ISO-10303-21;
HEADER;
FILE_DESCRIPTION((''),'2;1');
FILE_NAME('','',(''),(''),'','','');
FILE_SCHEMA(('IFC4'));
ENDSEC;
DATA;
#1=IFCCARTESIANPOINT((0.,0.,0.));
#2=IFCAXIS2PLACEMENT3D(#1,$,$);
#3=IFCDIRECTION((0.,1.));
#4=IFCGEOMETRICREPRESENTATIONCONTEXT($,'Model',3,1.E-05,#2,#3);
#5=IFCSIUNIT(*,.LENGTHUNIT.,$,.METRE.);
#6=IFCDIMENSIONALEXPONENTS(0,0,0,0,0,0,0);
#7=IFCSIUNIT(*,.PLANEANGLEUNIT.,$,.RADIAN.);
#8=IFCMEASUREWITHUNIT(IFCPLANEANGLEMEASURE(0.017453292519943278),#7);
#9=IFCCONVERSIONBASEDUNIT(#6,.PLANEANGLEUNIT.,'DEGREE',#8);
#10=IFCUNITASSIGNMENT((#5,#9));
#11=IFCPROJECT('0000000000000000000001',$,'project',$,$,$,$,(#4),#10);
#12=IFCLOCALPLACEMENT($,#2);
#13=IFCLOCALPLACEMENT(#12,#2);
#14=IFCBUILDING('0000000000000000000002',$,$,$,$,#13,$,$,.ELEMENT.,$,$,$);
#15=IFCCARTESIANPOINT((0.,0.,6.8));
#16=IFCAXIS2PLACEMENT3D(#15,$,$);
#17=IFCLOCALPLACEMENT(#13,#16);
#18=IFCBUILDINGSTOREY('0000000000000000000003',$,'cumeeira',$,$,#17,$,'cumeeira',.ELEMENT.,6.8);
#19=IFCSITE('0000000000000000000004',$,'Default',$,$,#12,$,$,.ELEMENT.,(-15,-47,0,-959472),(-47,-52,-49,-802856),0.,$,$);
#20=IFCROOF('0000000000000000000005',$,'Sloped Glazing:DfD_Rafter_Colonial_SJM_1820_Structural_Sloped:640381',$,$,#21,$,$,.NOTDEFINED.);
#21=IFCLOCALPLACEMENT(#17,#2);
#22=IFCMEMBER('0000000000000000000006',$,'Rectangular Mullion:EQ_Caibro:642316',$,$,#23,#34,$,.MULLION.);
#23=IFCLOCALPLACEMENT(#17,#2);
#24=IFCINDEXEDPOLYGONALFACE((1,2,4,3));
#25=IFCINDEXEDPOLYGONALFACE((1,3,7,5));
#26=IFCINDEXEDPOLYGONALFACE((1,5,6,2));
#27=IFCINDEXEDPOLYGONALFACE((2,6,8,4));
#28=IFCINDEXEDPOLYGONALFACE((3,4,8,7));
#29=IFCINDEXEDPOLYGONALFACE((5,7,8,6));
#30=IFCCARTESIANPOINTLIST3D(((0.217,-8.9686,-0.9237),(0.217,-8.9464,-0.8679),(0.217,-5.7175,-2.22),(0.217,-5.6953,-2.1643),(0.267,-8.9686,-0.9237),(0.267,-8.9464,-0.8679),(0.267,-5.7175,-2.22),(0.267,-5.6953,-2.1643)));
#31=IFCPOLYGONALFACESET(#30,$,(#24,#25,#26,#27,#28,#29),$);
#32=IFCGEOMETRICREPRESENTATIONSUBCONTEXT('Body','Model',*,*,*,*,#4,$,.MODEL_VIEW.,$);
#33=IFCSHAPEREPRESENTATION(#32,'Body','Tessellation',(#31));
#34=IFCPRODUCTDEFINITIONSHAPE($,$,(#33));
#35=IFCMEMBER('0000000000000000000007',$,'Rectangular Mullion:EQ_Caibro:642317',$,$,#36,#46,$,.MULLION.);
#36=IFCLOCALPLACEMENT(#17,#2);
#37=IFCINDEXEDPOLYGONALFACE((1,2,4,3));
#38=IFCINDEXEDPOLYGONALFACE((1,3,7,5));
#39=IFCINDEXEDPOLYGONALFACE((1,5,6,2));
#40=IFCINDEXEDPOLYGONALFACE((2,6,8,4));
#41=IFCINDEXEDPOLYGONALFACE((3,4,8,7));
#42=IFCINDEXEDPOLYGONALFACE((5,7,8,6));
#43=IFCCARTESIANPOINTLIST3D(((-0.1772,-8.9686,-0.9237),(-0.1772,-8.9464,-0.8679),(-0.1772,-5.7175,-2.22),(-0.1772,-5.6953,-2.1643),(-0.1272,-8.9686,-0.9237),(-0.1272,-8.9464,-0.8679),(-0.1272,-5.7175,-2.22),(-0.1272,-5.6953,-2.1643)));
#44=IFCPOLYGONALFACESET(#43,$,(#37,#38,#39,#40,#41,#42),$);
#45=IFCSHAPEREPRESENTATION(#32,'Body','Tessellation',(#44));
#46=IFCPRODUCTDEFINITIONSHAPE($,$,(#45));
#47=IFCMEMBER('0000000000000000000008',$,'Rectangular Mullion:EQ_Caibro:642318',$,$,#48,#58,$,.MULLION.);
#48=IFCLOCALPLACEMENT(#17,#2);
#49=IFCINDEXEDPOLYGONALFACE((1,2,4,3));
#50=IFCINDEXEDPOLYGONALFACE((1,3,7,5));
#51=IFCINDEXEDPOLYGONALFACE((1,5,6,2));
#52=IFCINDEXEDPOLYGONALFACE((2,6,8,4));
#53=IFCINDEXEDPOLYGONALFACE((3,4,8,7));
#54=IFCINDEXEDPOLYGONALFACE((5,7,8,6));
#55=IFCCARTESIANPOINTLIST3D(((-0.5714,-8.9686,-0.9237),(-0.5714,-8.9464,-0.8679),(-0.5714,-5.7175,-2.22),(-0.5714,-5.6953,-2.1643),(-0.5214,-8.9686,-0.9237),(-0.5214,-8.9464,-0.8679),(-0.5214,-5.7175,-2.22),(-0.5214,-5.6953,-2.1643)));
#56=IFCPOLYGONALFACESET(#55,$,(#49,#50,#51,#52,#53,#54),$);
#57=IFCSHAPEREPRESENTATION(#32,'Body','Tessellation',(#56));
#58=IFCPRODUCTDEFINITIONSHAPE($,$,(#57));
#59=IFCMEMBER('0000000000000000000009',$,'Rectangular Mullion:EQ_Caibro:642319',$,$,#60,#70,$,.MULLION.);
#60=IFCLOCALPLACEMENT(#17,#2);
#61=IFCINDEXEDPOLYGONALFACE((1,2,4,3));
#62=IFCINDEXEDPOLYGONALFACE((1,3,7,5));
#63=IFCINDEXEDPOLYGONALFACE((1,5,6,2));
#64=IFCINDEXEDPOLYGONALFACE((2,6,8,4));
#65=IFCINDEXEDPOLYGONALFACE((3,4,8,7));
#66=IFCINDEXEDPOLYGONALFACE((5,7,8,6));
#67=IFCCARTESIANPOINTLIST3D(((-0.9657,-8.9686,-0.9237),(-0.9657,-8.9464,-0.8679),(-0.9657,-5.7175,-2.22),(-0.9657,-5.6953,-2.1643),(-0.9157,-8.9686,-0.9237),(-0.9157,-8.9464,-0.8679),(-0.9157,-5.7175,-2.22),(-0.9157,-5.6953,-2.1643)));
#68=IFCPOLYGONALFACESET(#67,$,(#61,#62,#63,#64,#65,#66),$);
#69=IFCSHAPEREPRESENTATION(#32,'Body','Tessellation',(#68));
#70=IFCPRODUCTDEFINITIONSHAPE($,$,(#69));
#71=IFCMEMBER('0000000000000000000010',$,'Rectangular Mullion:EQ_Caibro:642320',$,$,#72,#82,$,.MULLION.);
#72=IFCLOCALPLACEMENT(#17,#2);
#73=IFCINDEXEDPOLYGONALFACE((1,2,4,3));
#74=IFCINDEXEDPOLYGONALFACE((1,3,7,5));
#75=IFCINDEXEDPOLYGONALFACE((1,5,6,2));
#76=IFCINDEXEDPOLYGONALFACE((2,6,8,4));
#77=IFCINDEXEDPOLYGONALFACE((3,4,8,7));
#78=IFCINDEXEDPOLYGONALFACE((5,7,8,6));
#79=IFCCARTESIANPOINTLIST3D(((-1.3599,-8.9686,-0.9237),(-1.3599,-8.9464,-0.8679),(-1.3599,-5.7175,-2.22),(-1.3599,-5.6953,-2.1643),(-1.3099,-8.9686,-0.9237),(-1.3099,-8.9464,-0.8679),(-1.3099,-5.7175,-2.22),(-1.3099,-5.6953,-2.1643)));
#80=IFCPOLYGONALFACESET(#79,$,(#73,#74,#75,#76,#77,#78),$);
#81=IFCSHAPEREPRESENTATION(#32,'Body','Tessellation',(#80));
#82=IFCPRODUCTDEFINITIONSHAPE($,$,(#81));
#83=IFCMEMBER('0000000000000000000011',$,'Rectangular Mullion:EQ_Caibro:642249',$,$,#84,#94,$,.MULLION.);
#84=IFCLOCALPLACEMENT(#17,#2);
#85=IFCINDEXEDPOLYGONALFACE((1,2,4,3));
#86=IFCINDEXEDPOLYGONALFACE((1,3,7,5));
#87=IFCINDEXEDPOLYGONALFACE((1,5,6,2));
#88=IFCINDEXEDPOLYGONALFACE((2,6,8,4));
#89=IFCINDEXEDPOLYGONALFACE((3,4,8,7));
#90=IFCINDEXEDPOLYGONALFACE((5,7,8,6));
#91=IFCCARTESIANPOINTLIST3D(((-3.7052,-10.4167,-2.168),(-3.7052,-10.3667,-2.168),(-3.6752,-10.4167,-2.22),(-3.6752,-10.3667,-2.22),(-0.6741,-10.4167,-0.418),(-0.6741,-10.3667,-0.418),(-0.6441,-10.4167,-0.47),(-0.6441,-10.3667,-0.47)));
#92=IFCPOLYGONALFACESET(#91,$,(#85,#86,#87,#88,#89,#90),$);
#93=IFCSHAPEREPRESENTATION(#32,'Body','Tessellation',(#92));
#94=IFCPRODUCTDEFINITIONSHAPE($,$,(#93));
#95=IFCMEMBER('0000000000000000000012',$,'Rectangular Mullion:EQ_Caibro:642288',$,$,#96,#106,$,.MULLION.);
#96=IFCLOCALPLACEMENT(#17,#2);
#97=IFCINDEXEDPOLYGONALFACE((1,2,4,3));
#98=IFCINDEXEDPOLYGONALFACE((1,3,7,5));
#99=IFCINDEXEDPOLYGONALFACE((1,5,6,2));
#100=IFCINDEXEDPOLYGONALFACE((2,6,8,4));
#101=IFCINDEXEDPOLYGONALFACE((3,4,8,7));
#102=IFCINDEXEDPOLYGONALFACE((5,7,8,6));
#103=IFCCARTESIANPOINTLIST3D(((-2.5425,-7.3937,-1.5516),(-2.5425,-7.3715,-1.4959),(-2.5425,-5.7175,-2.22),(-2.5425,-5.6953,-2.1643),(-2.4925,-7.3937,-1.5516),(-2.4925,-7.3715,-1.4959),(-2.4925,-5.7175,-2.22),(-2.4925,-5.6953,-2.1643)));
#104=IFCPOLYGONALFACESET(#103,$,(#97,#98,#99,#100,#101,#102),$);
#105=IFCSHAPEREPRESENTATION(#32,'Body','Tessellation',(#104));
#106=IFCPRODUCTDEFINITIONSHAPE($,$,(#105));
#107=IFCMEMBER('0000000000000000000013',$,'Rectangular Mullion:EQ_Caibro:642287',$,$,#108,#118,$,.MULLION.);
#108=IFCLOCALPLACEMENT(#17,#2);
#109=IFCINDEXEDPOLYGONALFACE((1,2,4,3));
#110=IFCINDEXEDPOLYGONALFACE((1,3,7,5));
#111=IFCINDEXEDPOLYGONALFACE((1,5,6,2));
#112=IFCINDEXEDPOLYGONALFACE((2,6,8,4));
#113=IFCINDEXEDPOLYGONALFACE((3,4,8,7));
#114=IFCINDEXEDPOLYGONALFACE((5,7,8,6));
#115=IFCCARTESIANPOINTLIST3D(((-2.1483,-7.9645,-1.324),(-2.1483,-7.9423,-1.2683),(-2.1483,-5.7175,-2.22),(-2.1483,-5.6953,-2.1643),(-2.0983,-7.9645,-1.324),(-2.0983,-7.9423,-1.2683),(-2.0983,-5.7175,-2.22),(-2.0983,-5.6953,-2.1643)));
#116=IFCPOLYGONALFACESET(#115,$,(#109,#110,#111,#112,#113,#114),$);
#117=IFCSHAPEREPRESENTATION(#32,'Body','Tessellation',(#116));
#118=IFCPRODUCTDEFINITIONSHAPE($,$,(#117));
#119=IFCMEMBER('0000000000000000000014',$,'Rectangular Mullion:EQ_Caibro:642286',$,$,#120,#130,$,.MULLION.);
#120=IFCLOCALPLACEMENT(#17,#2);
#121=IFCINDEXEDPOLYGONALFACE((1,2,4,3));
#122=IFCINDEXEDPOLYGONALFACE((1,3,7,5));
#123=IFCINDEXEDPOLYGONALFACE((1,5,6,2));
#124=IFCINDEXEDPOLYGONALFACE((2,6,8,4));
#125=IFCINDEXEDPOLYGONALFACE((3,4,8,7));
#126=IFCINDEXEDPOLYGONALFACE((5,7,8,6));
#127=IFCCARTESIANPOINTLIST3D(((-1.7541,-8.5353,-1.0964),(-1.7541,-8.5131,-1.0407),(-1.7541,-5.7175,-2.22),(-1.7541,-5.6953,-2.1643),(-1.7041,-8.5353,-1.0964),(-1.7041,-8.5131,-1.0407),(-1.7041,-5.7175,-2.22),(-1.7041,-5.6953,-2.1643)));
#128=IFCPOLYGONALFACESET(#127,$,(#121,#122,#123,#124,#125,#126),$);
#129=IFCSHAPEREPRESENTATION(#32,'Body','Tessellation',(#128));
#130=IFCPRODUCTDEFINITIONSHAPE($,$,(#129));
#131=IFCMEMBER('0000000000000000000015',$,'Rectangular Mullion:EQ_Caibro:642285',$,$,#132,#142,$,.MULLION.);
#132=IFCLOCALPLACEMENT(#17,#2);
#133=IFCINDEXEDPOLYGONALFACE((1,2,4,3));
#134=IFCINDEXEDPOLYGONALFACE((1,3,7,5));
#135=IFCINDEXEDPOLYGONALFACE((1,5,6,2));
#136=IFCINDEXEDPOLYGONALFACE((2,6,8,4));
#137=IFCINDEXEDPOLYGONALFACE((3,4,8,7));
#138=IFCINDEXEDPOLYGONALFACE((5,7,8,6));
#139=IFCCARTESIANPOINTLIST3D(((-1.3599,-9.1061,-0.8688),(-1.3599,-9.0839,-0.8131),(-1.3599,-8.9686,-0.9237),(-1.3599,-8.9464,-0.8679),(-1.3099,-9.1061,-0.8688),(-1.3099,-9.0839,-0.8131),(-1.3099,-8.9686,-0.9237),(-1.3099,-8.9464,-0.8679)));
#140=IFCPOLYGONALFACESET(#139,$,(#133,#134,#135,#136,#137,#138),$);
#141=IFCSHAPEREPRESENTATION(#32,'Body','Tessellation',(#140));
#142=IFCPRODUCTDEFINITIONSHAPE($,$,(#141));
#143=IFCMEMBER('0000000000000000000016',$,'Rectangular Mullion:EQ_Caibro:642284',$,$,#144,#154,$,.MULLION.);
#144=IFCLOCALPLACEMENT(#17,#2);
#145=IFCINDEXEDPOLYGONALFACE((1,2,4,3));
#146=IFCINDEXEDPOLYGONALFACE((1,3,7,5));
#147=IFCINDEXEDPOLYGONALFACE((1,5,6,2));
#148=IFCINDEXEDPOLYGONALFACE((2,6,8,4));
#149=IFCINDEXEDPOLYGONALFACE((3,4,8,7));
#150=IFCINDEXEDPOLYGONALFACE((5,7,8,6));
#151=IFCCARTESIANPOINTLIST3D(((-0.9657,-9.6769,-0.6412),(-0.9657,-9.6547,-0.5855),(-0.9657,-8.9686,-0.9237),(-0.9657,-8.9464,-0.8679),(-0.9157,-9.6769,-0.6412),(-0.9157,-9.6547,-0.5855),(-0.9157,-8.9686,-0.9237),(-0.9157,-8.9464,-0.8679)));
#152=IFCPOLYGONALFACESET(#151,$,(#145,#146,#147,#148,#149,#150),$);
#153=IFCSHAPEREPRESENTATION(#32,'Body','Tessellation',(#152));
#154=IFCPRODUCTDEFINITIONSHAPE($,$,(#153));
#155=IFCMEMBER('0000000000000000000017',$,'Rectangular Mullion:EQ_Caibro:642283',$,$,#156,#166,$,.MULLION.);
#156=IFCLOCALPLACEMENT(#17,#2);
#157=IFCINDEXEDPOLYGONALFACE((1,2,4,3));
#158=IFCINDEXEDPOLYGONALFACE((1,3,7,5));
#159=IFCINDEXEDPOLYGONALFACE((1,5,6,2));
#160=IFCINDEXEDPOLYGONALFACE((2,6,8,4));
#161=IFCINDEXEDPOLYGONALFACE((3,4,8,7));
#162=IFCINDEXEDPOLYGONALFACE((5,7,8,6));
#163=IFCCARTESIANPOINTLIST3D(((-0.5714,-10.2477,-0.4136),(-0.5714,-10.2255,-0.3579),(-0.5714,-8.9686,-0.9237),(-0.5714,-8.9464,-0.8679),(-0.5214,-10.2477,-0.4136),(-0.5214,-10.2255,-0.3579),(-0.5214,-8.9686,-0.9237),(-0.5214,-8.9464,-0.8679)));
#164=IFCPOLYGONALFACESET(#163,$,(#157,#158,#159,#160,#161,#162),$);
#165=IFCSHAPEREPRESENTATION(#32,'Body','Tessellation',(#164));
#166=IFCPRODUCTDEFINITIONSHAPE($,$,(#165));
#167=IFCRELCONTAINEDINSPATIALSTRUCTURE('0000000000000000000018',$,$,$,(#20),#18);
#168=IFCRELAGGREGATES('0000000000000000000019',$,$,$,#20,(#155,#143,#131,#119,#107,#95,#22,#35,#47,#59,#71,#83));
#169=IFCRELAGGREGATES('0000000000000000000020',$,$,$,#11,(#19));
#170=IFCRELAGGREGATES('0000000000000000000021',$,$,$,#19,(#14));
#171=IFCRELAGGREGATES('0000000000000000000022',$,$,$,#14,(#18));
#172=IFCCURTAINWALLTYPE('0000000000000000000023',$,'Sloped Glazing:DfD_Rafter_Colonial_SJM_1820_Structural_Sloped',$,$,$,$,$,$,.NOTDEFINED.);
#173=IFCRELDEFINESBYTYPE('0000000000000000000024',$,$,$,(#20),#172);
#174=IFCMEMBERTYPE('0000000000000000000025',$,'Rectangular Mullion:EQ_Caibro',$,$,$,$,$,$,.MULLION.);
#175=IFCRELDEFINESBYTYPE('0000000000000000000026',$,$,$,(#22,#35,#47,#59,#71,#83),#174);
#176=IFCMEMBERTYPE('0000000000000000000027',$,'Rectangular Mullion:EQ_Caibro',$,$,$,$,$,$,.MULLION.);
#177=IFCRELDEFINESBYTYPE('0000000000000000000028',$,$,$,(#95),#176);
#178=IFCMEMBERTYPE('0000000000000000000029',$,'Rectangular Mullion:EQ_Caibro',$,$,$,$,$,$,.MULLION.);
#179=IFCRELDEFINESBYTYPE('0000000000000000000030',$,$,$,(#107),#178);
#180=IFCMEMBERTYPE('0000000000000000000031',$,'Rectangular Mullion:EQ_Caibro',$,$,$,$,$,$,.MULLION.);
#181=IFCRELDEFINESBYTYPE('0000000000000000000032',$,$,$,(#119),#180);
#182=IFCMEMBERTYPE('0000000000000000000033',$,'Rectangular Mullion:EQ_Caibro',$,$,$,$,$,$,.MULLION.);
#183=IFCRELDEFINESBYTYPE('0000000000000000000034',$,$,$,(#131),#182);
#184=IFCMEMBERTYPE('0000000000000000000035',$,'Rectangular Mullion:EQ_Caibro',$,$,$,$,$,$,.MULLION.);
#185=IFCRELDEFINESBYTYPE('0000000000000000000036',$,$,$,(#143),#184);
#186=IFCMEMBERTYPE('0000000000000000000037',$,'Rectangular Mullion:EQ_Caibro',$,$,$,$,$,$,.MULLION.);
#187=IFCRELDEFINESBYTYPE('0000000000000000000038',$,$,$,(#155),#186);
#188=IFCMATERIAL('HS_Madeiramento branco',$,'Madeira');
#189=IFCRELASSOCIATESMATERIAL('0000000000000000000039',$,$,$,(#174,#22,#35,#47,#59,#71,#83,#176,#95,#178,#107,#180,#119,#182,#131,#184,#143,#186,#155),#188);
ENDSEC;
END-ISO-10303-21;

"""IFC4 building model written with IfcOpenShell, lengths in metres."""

from ifc_helpers import new_model, entity, si_unit, converted_unit, direction, frame, origin, place, context, subcontext, project, spatial, indexed_curve, outline, extrude, source, transform, mapped, material, type_object, type_shapes, element, aggregate, save


model = new_model("IFC4")

# Units and contexts
model_context = context("Model", 3, precision=1e-05, world=origin(), true_north=direction((0.0, 1.0)))
body_context = subcontext(model_context, "Body", "Model", "MODEL_VIEW")
ifc_project = project(units=[si_unit("LENGTHUNIT", "METRE"), converted_unit("PLANEANGLEUNIT", "DEGREE", entity("IfcPlaneAngleMeasure", 0.017453292519943278), si_unit("PLANEANGLEUNIT", "RADIAN"), dimensions=[0, 0, 0, 0, 0, 0, 0])], contexts=[model_context])

# Site, building, storey
site_placement = place(None, origin())
site = spatial("IfcSite", under=ifc_project, at=site_placement, Name="Default", CompositionType="ELEMENT", RefLatitude=(-15, -47, 0, -959472), RefLongitude=(-47, -52, -49, -802856), RefElevation=0.0)
building_placement = place(site_placement, origin())
building = spatial("IfcBuilding", under=site, at=building_placement, CompositionType="ELEMENT")
storey_placement = place(building_placement, frame((0.0, 0.0, 6.8)))
storey = spatial("IfcBuildingStorey", under=building, at=storey_placement, Name="cumeeira", LongName="cumeeira", CompositionType="ELEMENT", Elevation=6.8)

# Roof, members
curtain_wall_type = type_object("IfcCurtainWallType", Name="Sloped Glazing:DfD_Rafter_Colonial_SJM_1820_Structural_Sloped", PredefinedType="NOTDEFINED")
roof_placement = place(storey_placement, frame((0.0, 0.0, -6.8)))
roof = element("IfcRoof", 1, at=roof_placement, inside=storey, type_object=curtain_wall_type, Name="Sloped Glazing:DfD_Rafter_Colonial_SJM_1820_Structural_Sloped:640381", PredefinedType="NOTDEFINED")
ifc_material = material(Name="HS_Madeiramento branco", Category="Madeira")
member_type_1 = type_object("IfcMemberType", Name="Rectangular Mullion:EQ_Caibro", PredefinedType="MULLION", material=ifc_material)
shared_shape_1 = source(origin(), body_context, "Body", "SweptSolid", [
    extrude(outline(indexed_curve([(-0.025, -0.03), (0.025, -0.03), (0.025, 0.03), (-0.025, 0.03), (-0.025, -0.03)], self_intersect=False)), frame((0.0, -0.03, -3.5), z_axis=(0.0, 0.0, 1.0), x_axis=(-1.0, 0.0, 0.0)), (0.0, 0.0, 1.0), 3.5),
])
type_shapes(member_type_1, [shared_shape_1])
member_1_placement = place(roof_placement, frame((0.242, -8.9686, 5.8763), z_axis=(0.0, -0.928878, 0.370385), x_axis=(-1.0, 0.0, 0.0)))
member_1 = element("IfcMember", 2, at=member_1_placement, type_object=member_type_1, material=ifc_material, Name="Rectangular Mullion:EQ_Caibro:642316", PredefinedType="MULLION", context=body_context, shape_type="MappedRepresentation", body=[
    mapped(shared_shape_1, transform((0.0, 0.0, 0.0), scale=1.0)),
])
member_2_placement = place(roof_placement, frame((-0.1522, -8.9686, 5.8763), z_axis=(0.0, -0.928878, 0.370385), x_axis=(-1.0, 0.0, 0.0)))
member_2 = element("IfcMember", 3, at=member_2_placement, type_object=member_type_1, material=ifc_material, Name="Rectangular Mullion:EQ_Caibro:642317", PredefinedType="MULLION", context=body_context, shape_type="MappedRepresentation", body=[
    mapped(shared_shape_1, transform((0.0, 0.0, 0.0), scale=1.0)),
])
member_3_placement = place(roof_placement, frame((-0.5464, -8.9686, 5.8763), z_axis=(0.0, -0.928878, 0.370385), x_axis=(-1.0, 0.0, 0.0)))
member_3 = element("IfcMember", 4, at=member_3_placement, type_object=member_type_1, material=ifc_material, Name="Rectangular Mullion:EQ_Caibro:642318", PredefinedType="MULLION", context=body_context, shape_type="MappedRepresentation", body=[
    mapped(shared_shape_1, transform((0.0, 0.0, 0.0), scale=1.0)),
])
member_4_placement = place(roof_placement, frame((-0.9407, -8.9686, 5.8763), z_axis=(0.0, -0.928878, 0.370385), x_axis=(-1.0, 0.0, 0.0)))
member_4 = element("IfcMember", 5, at=member_4_placement, type_object=member_type_1, material=ifc_material, Name="Rectangular Mullion:EQ_Caibro:642319", PredefinedType="MULLION", context=body_context, shape_type="MappedRepresentation", body=[
    mapped(shared_shape_1, transform((0.0, 0.0, 0.0), scale=1.0)),
])
member_5_placement = place(roof_placement, frame((-1.3349, -8.9686, 5.8763), z_axis=(0.0, -0.928878, 0.370385), x_axis=(-1.0, 0.0, 0.0)))
member_5 = element("IfcMember", 6, at=member_5_placement, type_object=member_type_1, material=ifc_material, Name="Rectangular Mullion:EQ_Caibro:642320", PredefinedType="MULLION", context=body_context, shape_type="MappedRepresentation", body=[
    mapped(shared_shape_1, transform((0.0, 0.0, 0.0), scale=1.0)),
])
member_6_placement = place(roof_placement, frame((-0.6441, -10.3917, 6.33), z_axis=(0.866025, 0.0, 0.5), x_axis=(0.0, -1.0, 0.0)))
member_6 = element("IfcMember", 7, at=member_6_placement, type_object=member_type_1, material=ifc_material, Name="Rectangular Mullion:EQ_Caibro:642249", PredefinedType="MULLION", context=body_context, shape_type="MappedRepresentation", body=[
    mapped(shared_shape_1, transform((0.0, 0.0, 0.0), scale=1.0)),
])
member_type_2 = type_object("IfcMemberType", Name="Rectangular Mullion:EQ_Caibro", PredefinedType="MULLION", material=ifc_material)
shared_shape_2 = source(origin(), body_context, "Body", "SweptSolid", [
    extrude(outline(indexed_curve([(-0.025, -0.03), (0.025, -0.03), (0.025, 0.03), (-0.025, 0.03), (-0.025, -0.03)], self_intersect=False)), frame((0.0, -0.03, -1.8045), z_axis=(0.0, 0.0, 1.0), x_axis=(-1.0, 0.0, 0.0)), (0.0, 0.0, 1.0), 1.8045),
])
type_shapes(member_type_2, [shared_shape_2])
member_7_placement = place(roof_placement, frame((-2.5175, -7.3937, 5.2484), z_axis=(0.0, -0.928878, 0.370385), x_axis=(-1.0, 0.0, 0.0)))
member_7 = element("IfcMember", 8, at=member_7_placement, type_object=member_type_2, material=ifc_material, Name="Rectangular Mullion:EQ_Caibro:642288", PredefinedType="MULLION", context=body_context, shape_type="MappedRepresentation", body=[
    mapped(shared_shape_2, transform((0.0, 0.0, 0.0), scale=1.0)),
])
member_type_3 = type_object("IfcMemberType", Name="Rectangular Mullion:EQ_Caibro", PredefinedType="MULLION", material=ifc_material)
shared_shape_3 = source(origin(), body_context, "Body", "SweptSolid", [
    extrude(outline(indexed_curve([(-0.025, -0.03), (0.025, -0.03), (0.025, 0.03), (-0.025, 0.03), (-0.025, -0.03)], self_intersect=False)), frame((0.0, -0.03, -2.419), z_axis=(0.0, 0.0, 1.0), x_axis=(-1.0, 0.0, 0.0)), (0.0, 0.0, 1.0), 2.419),
])
type_shapes(member_type_3, [shared_shape_3])
member_8_placement = place(roof_placement, frame((-2.1233, -7.9645, 5.476), z_axis=(0.0, -0.928878, 0.370385), x_axis=(-1.0, 0.0, 0.0)))
member_8 = element("IfcMember", 9, at=member_8_placement, type_object=member_type_3, material=ifc_material, Name="Rectangular Mullion:EQ_Caibro:642287", PredefinedType="MULLION", context=body_context, shape_type="MappedRepresentation", body=[
    mapped(shared_shape_3, transform((0.0, 0.0, 0.0), scale=1.0)),
])
member_type_4 = type_object("IfcMemberType", Name="Rectangular Mullion:EQ_Caibro", PredefinedType="MULLION", material=ifc_material)
shared_shape_4 = source(origin(), body_context, "Body", "SweptSolid", [
    extrude(outline(indexed_curve([(-0.025, -0.03), (0.025, -0.03), (0.025, 0.03), (-0.025, 0.03), (-0.025, -0.03)], self_intersect=False)), frame((0.0, -0.03, -3.0335), z_axis=(0.0, 0.0, 1.0), x_axis=(-1.0, 0.0, 0.0)), (0.0, 0.0, 1.0), 3.0335),
])
type_shapes(member_type_4, [shared_shape_4])
member_9_placement = place(roof_placement, frame((-1.7291, -8.5353, 5.7036), z_axis=(0.0, -0.928878, 0.370385), x_axis=(-1.0, 0.0, 0.0)))
member_9 = element("IfcMember", 10, at=member_9_placement, type_object=member_type_4, material=ifc_material, Name="Rectangular Mullion:EQ_Caibro:642286", PredefinedType="MULLION", context=body_context, shape_type="MappedRepresentation", body=[
    mapped(shared_shape_4, transform((0.0, 0.0, 0.0), scale=1.0)),
])
member_type_5 = type_object("IfcMemberType", Name="Rectangular Mullion:EQ_Caibro", PredefinedType="MULLION", material=ifc_material)
shared_shape_5 = source(origin(), body_context, "Body", "SweptSolid", [
    extrude(outline(indexed_curve([(-0.025, -0.03), (0.025, -0.03), (0.025, 0.03), (-0.025, 0.03), (-0.025, -0.03)], self_intersect=False)), frame((0.0, -0.03, -0.148), z_axis=(0.0, 0.0, 1.0), x_axis=(-1.0, 0.0, 0.0)), (0.0, 0.0, 1.0), 0.148),
])
type_shapes(member_type_5, [shared_shape_5])
member_10_placement = place(roof_placement, frame((-1.3349, -9.1061, 5.9312), z_axis=(0.0, -0.928878, 0.370385), x_axis=(-1.0, 0.0, 0.0)))
member_10 = element("IfcMember", 11, at=member_10_placement, type_object=member_type_5, material=ifc_material, Name="Rectangular Mullion:EQ_Caibro:642285", PredefinedType="MULLION", context=body_context, shape_type="MappedRepresentation", body=[
    mapped(shared_shape_5, transform((0.0, 0.0, 0.0), scale=1.0)),
])
member_type_6 = type_object("IfcMemberType", Name="Rectangular Mullion:EQ_Caibro", PredefinedType="MULLION", material=ifc_material)
shared_shape_6 = source(origin(), body_context, "Body", "SweptSolid", [
    extrude(outline(indexed_curve([(-0.025, -0.03), (0.025, -0.03), (0.025, 0.03), (-0.025, 0.03), (-0.025, -0.03)], self_intersect=False)), frame((0.0, -0.03, -0.7625), z_axis=(0.0, 0.0, 1.0), x_axis=(-1.0, 0.0, 0.0)), (0.0, 0.0, 1.0), 0.7625),
])
type_shapes(member_type_6, [shared_shape_6])
member_11_placement = place(roof_placement, frame((-0.9407, -9.6769, 6.1588), z_axis=(0.0, -0.928878, 0.370385), x_axis=(-1.0, 0.0, 0.0)))
member_11 = element("IfcMember", 12, at=member_11_placement, type_object=member_type_6, material=ifc_material, Name="Rectangular Mullion:EQ_Caibro:642284", PredefinedType="MULLION", context=body_context, shape_type="MappedRepresentation", body=[
    mapped(shared_shape_6, transform((0.0, 0.0, 0.0), scale=1.0)),
])
member_type_7 = type_object("IfcMemberType", Name="Rectangular Mullion:EQ_Caibro", PredefinedType="MULLION", material=ifc_material)
shared_shape_7 = source(origin(), body_context, "Body", "SweptSolid", [
    extrude(outline(indexed_curve([(-0.025, -0.03), (0.025, -0.03), (0.025, 0.03), (-0.025, 0.03), (-0.025, -0.03)], self_intersect=False)), frame((0.0, -0.03, -1.377), z_axis=(0.0, 0.0, 1.0), x_axis=(-1.0, 0.0, 0.0)), (0.0, 0.0, 1.0), 1.377),
])
type_shapes(member_type_7, [shared_shape_7])
member_12_placement = place(roof_placement, frame((-0.5464, -10.2477, 6.3864), z_axis=(0.0, -0.928878, 0.370385), x_axis=(-1.0, 0.0, 0.0)))
member_12 = element("IfcMember", 13, at=member_12_placement, type_object=member_type_7, material=ifc_material, Name="Rectangular Mullion:EQ_Caibro:642283", PredefinedType="MULLION", context=body_context, shape_type="MappedRepresentation", body=[
    mapped(shared_shape_7, transform((0.0, 0.0, 0.0), scale=1.0)),
])
aggregate(roof, [member_12, member_11, member_10, member_9, member_8, member_7, member_1, member_2, member_3, member_4, member_5, member_6])

save(model, "model.ifc")
